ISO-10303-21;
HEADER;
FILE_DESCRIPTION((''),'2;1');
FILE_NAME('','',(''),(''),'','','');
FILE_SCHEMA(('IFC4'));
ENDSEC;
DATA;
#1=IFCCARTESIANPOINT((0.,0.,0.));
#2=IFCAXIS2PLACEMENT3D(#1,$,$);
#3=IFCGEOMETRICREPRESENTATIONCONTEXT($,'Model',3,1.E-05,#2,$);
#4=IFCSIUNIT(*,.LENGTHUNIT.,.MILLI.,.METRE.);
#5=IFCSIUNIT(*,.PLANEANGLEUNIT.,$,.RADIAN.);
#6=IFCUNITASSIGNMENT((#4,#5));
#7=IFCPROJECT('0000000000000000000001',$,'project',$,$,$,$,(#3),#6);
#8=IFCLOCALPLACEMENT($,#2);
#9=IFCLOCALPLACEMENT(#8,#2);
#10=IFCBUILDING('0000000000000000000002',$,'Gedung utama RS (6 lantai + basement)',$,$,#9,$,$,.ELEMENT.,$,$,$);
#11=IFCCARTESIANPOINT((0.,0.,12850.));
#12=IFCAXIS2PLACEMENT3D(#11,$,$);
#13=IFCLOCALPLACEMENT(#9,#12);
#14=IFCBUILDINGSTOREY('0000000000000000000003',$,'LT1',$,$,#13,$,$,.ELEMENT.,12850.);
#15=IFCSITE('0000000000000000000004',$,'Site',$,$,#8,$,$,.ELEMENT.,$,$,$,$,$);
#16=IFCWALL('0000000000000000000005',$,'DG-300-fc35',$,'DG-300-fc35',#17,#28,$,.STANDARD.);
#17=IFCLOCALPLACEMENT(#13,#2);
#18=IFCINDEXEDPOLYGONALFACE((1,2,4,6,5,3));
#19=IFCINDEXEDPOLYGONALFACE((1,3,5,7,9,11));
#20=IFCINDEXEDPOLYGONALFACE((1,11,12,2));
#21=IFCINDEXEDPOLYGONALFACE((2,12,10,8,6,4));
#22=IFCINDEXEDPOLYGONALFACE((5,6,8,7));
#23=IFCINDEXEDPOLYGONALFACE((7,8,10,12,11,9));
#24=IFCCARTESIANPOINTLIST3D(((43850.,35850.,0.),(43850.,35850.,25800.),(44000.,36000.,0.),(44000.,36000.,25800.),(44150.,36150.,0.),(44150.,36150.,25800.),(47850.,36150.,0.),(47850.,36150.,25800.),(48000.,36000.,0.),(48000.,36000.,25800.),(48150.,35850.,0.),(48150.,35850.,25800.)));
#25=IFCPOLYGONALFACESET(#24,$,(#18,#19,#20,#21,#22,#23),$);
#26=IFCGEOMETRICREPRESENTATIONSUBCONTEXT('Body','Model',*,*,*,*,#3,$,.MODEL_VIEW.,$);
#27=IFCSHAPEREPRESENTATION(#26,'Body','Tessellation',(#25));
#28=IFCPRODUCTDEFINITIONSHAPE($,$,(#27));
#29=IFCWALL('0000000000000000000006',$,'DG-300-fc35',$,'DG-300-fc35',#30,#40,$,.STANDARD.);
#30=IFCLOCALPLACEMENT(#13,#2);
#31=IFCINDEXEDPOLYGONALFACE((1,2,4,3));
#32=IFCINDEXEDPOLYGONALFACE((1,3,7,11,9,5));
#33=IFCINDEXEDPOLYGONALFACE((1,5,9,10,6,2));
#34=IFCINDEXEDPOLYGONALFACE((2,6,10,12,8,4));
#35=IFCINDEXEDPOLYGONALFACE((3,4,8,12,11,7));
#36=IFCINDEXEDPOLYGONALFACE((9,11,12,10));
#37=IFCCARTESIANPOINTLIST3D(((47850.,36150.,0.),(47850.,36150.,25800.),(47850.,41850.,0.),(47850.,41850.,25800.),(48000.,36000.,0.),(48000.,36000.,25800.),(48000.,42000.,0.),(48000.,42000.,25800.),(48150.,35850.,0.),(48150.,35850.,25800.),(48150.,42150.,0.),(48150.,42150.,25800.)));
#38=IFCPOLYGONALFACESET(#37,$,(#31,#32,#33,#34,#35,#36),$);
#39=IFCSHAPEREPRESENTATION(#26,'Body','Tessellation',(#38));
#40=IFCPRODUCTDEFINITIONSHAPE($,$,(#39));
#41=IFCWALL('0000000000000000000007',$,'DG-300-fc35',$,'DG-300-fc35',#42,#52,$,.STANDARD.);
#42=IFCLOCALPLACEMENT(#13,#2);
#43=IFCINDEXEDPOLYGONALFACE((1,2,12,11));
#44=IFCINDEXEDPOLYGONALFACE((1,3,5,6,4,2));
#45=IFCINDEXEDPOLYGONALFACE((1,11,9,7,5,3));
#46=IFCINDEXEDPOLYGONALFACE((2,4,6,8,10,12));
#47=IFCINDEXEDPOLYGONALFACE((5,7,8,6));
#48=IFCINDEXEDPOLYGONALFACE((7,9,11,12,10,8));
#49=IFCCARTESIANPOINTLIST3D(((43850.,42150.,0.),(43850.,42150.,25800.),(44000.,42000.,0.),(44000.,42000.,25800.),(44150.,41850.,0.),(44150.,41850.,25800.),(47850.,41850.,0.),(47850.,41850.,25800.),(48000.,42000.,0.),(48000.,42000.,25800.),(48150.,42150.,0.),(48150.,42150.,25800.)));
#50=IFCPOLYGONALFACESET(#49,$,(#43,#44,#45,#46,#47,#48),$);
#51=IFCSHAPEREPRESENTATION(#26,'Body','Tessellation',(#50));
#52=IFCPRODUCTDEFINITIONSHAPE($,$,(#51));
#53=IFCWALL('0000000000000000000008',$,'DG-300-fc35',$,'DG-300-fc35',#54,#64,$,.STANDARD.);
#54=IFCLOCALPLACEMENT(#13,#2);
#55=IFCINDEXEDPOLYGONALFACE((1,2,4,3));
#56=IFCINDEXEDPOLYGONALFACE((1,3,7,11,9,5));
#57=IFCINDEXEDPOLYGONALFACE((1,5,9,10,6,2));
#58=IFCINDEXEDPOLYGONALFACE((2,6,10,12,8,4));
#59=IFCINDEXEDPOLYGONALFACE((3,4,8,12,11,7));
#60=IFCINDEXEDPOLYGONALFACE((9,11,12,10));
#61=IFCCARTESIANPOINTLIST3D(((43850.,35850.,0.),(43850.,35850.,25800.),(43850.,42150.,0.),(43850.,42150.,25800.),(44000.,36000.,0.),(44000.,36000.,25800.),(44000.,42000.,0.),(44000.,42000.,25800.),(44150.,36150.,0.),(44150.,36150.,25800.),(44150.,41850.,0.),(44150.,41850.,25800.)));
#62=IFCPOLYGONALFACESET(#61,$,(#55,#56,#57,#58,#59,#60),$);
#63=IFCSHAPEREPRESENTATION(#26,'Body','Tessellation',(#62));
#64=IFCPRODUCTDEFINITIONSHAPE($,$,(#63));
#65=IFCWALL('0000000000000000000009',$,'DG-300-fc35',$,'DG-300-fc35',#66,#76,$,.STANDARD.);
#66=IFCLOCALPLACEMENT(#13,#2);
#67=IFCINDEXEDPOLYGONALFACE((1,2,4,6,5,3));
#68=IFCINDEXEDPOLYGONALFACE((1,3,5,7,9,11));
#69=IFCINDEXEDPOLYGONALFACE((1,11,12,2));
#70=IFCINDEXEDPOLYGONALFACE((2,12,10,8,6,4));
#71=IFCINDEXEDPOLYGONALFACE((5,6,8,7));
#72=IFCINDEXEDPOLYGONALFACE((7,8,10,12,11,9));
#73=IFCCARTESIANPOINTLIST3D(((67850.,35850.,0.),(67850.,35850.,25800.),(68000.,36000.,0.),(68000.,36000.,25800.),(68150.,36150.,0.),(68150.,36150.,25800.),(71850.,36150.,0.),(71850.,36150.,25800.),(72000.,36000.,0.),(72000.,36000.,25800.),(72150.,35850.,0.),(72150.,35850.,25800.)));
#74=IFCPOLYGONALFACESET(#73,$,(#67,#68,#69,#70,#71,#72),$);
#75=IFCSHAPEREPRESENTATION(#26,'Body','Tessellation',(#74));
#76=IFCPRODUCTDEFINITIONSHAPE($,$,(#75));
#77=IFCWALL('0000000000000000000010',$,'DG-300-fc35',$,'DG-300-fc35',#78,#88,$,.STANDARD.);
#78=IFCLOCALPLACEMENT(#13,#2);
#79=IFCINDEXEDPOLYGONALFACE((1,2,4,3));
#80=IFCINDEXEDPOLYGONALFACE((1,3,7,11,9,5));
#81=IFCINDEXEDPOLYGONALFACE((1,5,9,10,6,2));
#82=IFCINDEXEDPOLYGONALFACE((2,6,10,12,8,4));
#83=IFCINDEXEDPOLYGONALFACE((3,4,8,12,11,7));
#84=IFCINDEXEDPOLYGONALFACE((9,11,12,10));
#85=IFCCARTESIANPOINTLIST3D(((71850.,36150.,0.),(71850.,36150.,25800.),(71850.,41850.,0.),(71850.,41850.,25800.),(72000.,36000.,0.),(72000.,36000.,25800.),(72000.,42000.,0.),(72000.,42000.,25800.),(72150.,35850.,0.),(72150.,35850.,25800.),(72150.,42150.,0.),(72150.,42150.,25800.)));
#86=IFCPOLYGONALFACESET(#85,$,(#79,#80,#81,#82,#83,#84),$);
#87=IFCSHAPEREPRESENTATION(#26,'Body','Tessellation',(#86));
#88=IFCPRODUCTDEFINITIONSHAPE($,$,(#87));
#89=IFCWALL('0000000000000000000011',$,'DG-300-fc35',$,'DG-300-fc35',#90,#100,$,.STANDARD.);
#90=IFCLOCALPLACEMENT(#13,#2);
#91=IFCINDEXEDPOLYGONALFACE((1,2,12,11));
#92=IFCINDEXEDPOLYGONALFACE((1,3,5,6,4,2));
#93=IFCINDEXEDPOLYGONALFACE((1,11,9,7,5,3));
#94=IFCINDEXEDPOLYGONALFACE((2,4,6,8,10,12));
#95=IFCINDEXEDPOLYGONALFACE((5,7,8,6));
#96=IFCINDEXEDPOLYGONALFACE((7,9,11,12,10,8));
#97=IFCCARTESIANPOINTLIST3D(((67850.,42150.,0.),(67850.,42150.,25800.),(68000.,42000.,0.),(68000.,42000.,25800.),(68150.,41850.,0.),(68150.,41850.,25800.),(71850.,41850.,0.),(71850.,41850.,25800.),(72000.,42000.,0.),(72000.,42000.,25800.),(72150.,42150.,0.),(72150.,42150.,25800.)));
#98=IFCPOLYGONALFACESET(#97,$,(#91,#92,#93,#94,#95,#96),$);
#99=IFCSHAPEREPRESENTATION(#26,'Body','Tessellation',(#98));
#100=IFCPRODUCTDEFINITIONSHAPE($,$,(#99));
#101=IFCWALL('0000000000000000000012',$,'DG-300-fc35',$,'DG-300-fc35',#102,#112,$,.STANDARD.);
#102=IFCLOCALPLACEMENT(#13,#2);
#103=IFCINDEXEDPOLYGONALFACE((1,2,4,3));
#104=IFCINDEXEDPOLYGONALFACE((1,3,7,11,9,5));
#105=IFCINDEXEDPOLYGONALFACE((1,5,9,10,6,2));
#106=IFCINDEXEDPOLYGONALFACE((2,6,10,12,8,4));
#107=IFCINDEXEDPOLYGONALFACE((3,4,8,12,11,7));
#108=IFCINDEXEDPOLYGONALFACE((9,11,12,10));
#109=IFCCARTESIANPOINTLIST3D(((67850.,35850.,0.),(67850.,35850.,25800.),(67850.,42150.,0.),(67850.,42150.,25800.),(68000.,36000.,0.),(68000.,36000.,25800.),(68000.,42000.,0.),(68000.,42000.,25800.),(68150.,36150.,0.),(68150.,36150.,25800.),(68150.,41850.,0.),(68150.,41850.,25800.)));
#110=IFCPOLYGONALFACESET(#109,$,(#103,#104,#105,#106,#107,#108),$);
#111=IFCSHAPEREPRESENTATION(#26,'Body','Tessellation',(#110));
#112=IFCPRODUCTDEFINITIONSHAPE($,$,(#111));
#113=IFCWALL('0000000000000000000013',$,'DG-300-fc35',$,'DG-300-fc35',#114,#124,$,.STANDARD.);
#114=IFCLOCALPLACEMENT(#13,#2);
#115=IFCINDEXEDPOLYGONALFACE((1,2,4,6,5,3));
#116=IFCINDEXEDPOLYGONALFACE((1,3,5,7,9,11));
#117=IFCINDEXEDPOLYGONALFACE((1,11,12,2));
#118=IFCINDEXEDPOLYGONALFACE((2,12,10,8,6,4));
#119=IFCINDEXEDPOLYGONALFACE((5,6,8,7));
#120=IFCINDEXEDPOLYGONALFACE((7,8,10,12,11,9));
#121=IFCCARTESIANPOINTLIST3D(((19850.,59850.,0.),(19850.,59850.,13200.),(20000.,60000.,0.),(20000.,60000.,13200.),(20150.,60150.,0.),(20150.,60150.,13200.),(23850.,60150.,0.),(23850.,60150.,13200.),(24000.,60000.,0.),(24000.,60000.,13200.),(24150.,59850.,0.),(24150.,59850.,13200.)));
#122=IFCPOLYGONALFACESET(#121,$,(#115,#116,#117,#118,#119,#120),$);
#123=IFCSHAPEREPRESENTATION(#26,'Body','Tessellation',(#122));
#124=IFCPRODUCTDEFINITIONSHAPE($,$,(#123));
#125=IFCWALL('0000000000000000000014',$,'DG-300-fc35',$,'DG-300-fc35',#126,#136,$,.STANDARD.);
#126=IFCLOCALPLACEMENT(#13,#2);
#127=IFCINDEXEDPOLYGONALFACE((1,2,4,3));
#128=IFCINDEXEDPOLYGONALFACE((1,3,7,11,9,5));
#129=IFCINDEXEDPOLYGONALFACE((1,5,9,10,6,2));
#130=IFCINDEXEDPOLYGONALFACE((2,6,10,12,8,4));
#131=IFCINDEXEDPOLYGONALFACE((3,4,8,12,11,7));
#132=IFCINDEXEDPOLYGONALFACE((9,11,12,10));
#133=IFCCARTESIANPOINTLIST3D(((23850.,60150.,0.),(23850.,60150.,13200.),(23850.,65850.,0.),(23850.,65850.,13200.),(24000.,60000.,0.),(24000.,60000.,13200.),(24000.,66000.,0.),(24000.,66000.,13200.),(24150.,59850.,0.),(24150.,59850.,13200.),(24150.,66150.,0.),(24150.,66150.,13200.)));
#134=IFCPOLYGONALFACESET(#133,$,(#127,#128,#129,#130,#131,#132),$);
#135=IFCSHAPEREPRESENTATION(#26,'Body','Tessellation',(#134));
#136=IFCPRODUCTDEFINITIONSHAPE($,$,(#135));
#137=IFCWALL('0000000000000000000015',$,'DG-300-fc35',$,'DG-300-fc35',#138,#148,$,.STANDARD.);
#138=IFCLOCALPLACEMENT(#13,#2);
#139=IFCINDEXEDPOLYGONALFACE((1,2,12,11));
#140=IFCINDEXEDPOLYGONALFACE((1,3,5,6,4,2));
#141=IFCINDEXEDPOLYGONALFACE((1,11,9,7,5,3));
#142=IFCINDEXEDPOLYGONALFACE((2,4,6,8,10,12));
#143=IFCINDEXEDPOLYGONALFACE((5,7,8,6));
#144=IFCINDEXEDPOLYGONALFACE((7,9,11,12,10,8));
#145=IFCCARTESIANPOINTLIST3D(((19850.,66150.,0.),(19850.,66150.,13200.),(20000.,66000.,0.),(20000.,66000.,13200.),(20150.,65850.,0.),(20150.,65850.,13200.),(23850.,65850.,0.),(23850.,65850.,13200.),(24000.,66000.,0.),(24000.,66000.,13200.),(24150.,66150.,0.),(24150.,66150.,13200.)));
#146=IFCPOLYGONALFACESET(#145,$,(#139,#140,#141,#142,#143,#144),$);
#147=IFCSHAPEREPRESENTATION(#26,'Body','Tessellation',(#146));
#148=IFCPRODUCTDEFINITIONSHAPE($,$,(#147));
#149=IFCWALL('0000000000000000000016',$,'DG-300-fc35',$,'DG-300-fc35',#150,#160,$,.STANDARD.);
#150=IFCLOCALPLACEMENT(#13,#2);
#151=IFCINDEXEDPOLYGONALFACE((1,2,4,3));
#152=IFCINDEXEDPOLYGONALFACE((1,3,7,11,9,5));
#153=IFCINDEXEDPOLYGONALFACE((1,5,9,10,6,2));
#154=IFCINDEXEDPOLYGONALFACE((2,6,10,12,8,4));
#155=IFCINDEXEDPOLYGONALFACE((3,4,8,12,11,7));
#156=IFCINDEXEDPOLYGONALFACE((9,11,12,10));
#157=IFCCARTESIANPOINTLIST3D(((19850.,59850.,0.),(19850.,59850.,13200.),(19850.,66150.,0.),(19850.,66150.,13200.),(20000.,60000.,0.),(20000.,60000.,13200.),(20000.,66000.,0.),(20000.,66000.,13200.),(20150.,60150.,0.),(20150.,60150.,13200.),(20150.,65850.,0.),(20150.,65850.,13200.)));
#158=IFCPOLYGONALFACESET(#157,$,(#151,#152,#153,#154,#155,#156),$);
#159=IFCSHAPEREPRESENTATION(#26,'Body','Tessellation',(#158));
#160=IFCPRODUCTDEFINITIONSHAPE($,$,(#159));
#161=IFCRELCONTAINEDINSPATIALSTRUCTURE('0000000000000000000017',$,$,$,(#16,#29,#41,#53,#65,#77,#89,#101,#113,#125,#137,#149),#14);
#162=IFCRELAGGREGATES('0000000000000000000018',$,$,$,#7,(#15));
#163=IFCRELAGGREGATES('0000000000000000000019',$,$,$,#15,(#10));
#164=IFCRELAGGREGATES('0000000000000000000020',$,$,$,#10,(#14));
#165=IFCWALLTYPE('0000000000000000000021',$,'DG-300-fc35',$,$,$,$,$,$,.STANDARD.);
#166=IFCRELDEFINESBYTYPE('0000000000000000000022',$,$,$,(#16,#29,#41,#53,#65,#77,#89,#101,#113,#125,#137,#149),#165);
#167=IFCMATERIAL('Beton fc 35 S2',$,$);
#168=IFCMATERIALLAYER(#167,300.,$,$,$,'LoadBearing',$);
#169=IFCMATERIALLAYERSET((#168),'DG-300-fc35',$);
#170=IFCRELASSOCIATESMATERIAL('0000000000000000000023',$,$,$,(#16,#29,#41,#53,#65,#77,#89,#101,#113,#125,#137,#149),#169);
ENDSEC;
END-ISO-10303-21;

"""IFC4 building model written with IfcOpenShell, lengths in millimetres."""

from ifc_helpers import new_model, si_unit, frame, origin, place, context, subcontext, project, spatial, polyline, outline, extrude, material, layer, layer_set, layer_usage, type_object, element, save


model = new_model("IFC4")

# Units and contexts
model_context = context("Model", 3, precision=1e-05, world=origin())
body_context = subcontext(model_context, "Body", "Model", "MODEL_VIEW")
ifc_project = project(units=[si_unit("LENGTHUNIT", "METRE", prefix="MILLI"), si_unit("PLANEANGLEUNIT", "RADIAN")], contexts=[model_context])

# Site, building, storey
site_placement = place(None, origin())
site = spatial("IfcSite", under=ifc_project, at=site_placement, Name="Site", CompositionType="ELEMENT")
building_placement = place(site_placement, origin())
building = spatial("IfcBuilding", under=site, at=building_placement, Name="Gedung utama RS (6 lantai + basement)", CompositionType="ELEMENT")
storey_placement = place(building_placement, frame((0.0, 0.0, 12850.0)))
storey = spatial("IfcBuildingStorey", under=building, at=storey_placement, Name="LT1", CompositionType="ELEMENT", Elevation=12850.0)

# Walls
ifc_material_1 = material(Name="Beton fc 35 S2")
ifc_layer_1 = layer(ifc_material_1, 300.0, Category="LoadBearing")
ifc_layer_set_1 = layer_set([ifc_layer_1], Name="DG-300-fc35")
ifc_layer_usage_1 = layer_usage(ifc_layer_set_1, "AXIS2", "NEGATIVE", 150.0)
wall_type_1 = type_object("IfcWallType", Name="DG-300-fc35", PredefinedType="STANDARD")
wall_1_placement = place(storey_placement, frame((44000.0, 36000.0, 0.0), z_axis=(0.0, 0.0, 1.0), x_axis=(1.0, 0.0, 0.0)))
element("IfcWall", 1, at=wall_1_placement, inside=storey, type_object=wall_type_1, material=ifc_layer_usage_1, Name="DG-300-fc35", ObjectType="DG-300-fc35", PredefinedType="STANDARD", context=body_context, shape_type="SweptSolid", body=[
    extrude(outline(polyline([(-150.0, -150.0), (0.0, 0.0), (150.0, 150.0), (3850.0, 150.0), (4000.0, 0.0), (4150.0, -150.0), (-150.0, -150.0)])), origin(), (0.0, 0.0, 1.0), 25800.0),
])
wall_2_placement = place(storey_placement, frame((48000.0, 36000.0, 0.0), z_axis=(0.0, 0.0, 1.0), x_axis=(0.0, 1.0, 0.0)))
element("IfcWall", 2, at=wall_2_placement, inside=storey, type_object=wall_type_1, material=ifc_layer_usage_1, Name="DG-300-fc35", ObjectType="DG-300-fc35", PredefinedType="STANDARD", context=body_context, shape_type="SweptSolid", body=[
    extrude(outline(polyline([(-150.0, -150.0), (0.0, 0.0), (150.0, 150.0), (5850.0, 150.0), (6000.0, 0.0), (6150.0, -150.0), (-150.0, -150.0)])), origin(), (0.0, 0.0, 1.0), 25800.0),
])
wall_3_placement = place(storey_placement, frame((48000.0, 42000.0, 0.0), z_axis=(0.0, 0.0, 1.0), x_axis=(-1.0, 0.0, 0.0)))
element("IfcWall", 3, at=wall_3_placement, inside=storey, type_object=wall_type_1, material=ifc_layer_usage_1, Name="DG-300-fc35", ObjectType="DG-300-fc35", PredefinedType="STANDARD", context=body_context, shape_type="SweptSolid", body=[
    extrude(outline(polyline([(-150.0, -150.0), (0.0, 0.0), (150.0, 150.0), (3850.0, 150.0), (4000.0, 0.0), (4150.0, -150.0), (-150.0, -150.0)])), origin(), (0.0, 0.0, 1.0), 25800.0),
])
wall_4_placement = place(storey_placement, frame((44000.0, 42000.0, 0.0), z_axis=(0.0, 0.0, 1.0), x_axis=(0.0, -1.0, 0.0)))
element("IfcWall", 4, at=wall_4_placement, inside=storey, type_object=wall_type_1, material=ifc_layer_usage_1, Name="DG-300-fc35", ObjectType="DG-300-fc35", PredefinedType="STANDARD", context=body_context, shape_type="SweptSolid", body=[
    extrude(outline(polyline([(-150.0, -150.0), (0.0, 0.0), (150.0, 150.0), (5850.0, 150.0), (6000.0, 0.0), (6150.0, -150.0), (-150.0, -150.0)])), origin(), (0.0, 0.0, 1.0), 25800.0),
])
wall_5_placement = place(storey_placement, frame((68000.0, 36000.0, 0.0), z_axis=(0.0, 0.0, 1.0), x_axis=(1.0, 0.0, 0.0)))
element("IfcWall", 5, at=wall_5_placement, inside=storey, type_object=wall_type_1, material=ifc_layer_usage_1, Name="DG-300-fc35", ObjectType="DG-300-fc35", PredefinedType="STANDARD", context=body_context, shape_type="SweptSolid", body=[
    extrude(outline(polyline([(-150.0, -150.0), (0.0, 0.0), (150.0, 150.0), (3850.0, 150.0), (4000.0, 0.0), (4150.0, -150.0), (-150.0, -150.0)])), origin(), (0.0, 0.0, 1.0), 25800.0),
])
wall_6_placement = place(storey_placement, frame((72000.0, 36000.0, 0.0), z_axis=(0.0, 0.0, 1.0), x_axis=(0.0, 1.0, 0.0)))
element("IfcWall", 6, at=wall_6_placement, inside=storey, type_object=wall_type_1, material=ifc_layer_usage_1, Name="DG-300-fc35", ObjectType="DG-300-fc35", PredefinedType="STANDARD", context=body_context, shape_type="SweptSolid", body=[
    extrude(outline(polyline([(-150.0, -150.0), (0.0, 0.0), (150.0, 150.0), (5850.0, 150.0), (6000.0, 0.0), (6150.0, -150.0), (-150.0, -150.0)])), origin(), (0.0, 0.0, 1.0), 25800.0),
])
wall_7_placement = place(storey_placement, frame((72000.0, 42000.0, 0.0), z_axis=(0.0, 0.0, 1.0), x_axis=(-1.0, 0.0, 0.0)))
element("IfcWall", 7, at=wall_7_placement, inside=storey, type_object=wall_type_1, material=ifc_layer_usage_1, Name="DG-300-fc35", ObjectType="DG-300-fc35", PredefinedType="STANDARD", context=body_context, shape_type="SweptSolid", body=[
    extrude(outline(polyline([(-150.0, -150.0), (0.0, 0.0), (150.0, 150.0), (3850.0, 150.0), (4000.0, 0.0), (4150.0, -150.0), (-150.0, -150.0)])), origin(), (0.0, 0.0, 1.0), 25800.0),
])
wall_8_placement = place(storey_placement, frame((68000.0, 42000.0, 0.0), z_axis=(0.0, 0.0, 1.0), x_axis=(0.0, -1.0, 0.0)))
element("IfcWall", 8, at=wall_8_placement, inside=storey, type_object=wall_type_1, material=ifc_layer_usage_1, Name="DG-300-fc35", ObjectType="DG-300-fc35", PredefinedType="STANDARD", context=body_context, shape_type="SweptSolid", body=[
    extrude(outline(polyline([(-150.0, -150.0), (0.0, 0.0), (150.0, 150.0), (5850.0, 150.0), (6000.0, 0.0), (6150.0, -150.0), (-150.0, -150.0)])), origin(), (0.0, 0.0, 1.0), 25800.0),
])
wall_9_placement = place(storey_placement, frame((20000.0, 60000.0, 0.0), z_axis=(0.0, 0.0, 1.0), x_axis=(1.0, 0.0, 0.0)))
element("IfcWall", 9, at=wall_9_placement, inside=storey, type_object=wall_type_1, material=ifc_layer_usage_1, Name="DG-300-fc35", ObjectType="DG-300-fc35", PredefinedType="STANDARD", context=body_context, shape_type="SweptSolid", body=[
    extrude(outline(polyline([(-150.0, -150.0), (0.0, 0.0), (150.0, 150.0), (3850.0, 150.0), (4000.0, 0.0), (4150.0, -150.0), (-150.0, -150.0)])), origin(), (0.0, 0.0, 1.0), 13200.0),
])
wall_10_placement = place(storey_placement, frame((24000.0, 60000.0, 0.0), z_axis=(0.0, 0.0, 1.0), x_axis=(0.0, 1.0, 0.0)))
element("IfcWall", 10, at=wall_10_placement, inside=storey, type_object=wall_type_1, material=ifc_layer_usage_1, Name="DG-300-fc35", ObjectType="DG-300-fc35", PredefinedType="STANDARD", context=body_context, shape_type="SweptSolid", body=[
    extrude(outline(polyline([(-150.0, -150.0), (0.0, 0.0), (150.0, 150.0), (5850.0, 150.0), (6000.0, 0.0), (6150.0, -150.0), (-150.0, -150.0)])), origin(), (0.0, 0.0, 1.0), 13200.0),
])
wall_11_placement = place(storey_placement, frame((24000.0, 66000.0, 0.0), z_axis=(0.0, 0.0, 1.0), x_axis=(-1.0, 0.0, 0.0)))
element("IfcWall", 11, at=wall_11_placement, inside=storey, type_object=wall_type_1, material=ifc_layer_usage_1, Name="DG-300-fc35", ObjectType="DG-300-fc35", PredefinedType="STANDARD", context=body_context, shape_type="SweptSolid", body=[
    extrude(outline(polyline([(-150.0, -150.0), (0.0, 0.0), (150.0, 150.0), (3850.0, 150.0), (4000.0, 0.0), (4150.0, -150.0), (-150.0, -150.0)])), origin(), (0.0, 0.0, 1.0), 13200.0),
])
wall_12_placement = place(storey_placement, frame((20000.0, 66000.0, 0.0), z_axis=(0.0, 0.0, 1.0), x_axis=(0.0, -1.0, 0.0)))
element("IfcWall", 12, at=wall_12_placement, inside=storey, type_object=wall_type_1, material=ifc_layer_usage_1, Name="DG-300-fc35", ObjectType="DG-300-fc35", PredefinedType="STANDARD", context=body_context, shape_type="SweptSolid", body=[
    extrude(outline(polyline([(-150.0, -150.0), (0.0, 0.0), (150.0, 150.0), (5850.0, 150.0), (6000.0, 0.0), (6150.0, -150.0), (-150.0, -150.0)])), origin(), (0.0, 0.0, 1.0), 13200.0),
])

save(model, "model.ifc")
